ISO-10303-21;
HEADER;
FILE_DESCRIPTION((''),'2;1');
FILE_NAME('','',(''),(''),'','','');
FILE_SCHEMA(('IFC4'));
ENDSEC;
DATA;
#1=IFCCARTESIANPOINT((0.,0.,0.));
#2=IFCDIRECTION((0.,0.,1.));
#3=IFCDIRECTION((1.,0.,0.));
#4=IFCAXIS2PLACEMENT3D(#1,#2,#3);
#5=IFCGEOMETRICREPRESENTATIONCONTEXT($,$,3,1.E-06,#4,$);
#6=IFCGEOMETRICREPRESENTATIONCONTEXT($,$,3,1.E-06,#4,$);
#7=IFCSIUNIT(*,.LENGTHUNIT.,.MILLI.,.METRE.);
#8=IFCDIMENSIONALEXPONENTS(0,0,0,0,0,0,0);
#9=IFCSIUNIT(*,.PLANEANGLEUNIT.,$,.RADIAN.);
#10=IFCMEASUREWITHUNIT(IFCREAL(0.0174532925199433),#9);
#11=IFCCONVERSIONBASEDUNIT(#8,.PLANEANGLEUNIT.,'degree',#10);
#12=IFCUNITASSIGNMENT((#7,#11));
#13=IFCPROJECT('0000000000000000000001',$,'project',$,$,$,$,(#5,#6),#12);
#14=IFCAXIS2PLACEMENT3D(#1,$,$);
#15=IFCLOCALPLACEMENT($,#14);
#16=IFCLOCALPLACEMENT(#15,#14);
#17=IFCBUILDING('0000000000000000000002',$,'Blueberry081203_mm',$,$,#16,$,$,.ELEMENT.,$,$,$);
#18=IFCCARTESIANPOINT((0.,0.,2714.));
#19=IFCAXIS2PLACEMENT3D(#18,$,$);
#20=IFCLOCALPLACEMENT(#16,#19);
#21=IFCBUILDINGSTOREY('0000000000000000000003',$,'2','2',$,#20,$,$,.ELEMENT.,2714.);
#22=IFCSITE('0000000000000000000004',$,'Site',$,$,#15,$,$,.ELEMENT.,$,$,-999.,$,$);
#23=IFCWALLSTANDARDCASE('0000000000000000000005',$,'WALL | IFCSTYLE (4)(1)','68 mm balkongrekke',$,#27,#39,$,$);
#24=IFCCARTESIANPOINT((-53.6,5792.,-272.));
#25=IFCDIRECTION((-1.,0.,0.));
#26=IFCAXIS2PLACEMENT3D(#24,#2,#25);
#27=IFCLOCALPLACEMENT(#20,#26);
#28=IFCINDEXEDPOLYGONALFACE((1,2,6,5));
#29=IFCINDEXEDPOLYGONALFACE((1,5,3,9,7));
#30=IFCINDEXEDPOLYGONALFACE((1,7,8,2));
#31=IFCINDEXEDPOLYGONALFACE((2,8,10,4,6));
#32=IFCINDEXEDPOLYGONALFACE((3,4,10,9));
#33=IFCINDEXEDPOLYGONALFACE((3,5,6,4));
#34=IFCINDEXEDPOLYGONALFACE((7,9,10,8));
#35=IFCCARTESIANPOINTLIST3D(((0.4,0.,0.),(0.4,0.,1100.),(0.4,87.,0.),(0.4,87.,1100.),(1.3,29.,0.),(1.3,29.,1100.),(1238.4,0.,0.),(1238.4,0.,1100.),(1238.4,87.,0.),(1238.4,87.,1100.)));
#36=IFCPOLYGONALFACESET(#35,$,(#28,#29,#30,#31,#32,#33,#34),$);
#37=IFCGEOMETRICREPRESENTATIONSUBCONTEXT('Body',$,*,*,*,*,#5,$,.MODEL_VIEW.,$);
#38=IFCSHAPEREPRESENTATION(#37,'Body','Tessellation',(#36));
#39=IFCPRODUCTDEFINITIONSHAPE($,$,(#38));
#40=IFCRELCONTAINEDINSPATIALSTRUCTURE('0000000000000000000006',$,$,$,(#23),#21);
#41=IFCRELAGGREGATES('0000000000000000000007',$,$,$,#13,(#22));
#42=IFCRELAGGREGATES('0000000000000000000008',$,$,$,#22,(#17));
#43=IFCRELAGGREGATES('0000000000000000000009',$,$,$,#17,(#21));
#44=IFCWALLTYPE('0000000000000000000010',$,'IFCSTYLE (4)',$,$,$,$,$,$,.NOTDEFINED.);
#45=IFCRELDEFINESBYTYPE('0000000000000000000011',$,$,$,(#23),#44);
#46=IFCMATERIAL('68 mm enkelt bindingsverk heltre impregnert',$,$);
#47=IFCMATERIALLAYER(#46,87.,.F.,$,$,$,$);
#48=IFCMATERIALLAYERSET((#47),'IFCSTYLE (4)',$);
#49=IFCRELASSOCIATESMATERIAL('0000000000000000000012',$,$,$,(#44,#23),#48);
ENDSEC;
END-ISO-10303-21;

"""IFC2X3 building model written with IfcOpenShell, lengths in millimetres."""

from ifc_helpers import new_model, entity, si_unit, converted_unit, frame, origin, origin_with_axes, place, context, subcontext, project, spatial, polyline, segment, composite_curve, outline, extrude, material, layer, layer_set, layer_usage, type_object, element, save


model = new_model("IFC2X3")

# Units and contexts
context_of_model_1 = context(None, 3, precision=1e-06, world=origin_with_axes())
context_of_model_2 = context(None, 3, precision=1e-06, world=origin_with_axes())
body_context = subcontext(context_of_model_1, "Body", None, "MODEL_VIEW")
ifc_project = project(units=[si_unit("LENGTHUNIT", "METRE", prefix="MILLI"), converted_unit("PLANEANGLEUNIT", "degree", entity("IfcReal", 0.0174532925199433), si_unit("PLANEANGLEUNIT", "RADIAN"), dimensions=[0, 0, 0, 0, 0, 0, 0])], contexts=[context_of_model_1, context_of_model_2])

# Site, building, storey
site_placement = place(None, origin())
site = spatial("IfcSite", under=ifc_project, at=site_placement, Name="Site", CompositionType="ELEMENT", RefElevation=-999.0)
building_placement = place(site_placement, origin())
building = spatial("IfcBuilding", under=site, at=building_placement, Name="Blueberry081203_mm", CompositionType="ELEMENT")
storey_placement = place(building_placement, frame((0.0, 0.0, 2714.0)))
storey = spatial("IfcBuildingStorey", under=building, at=storey_placement, Name="2", Description="2", CompositionType="ELEMENT", Elevation=2714.0)

# Wall
ifc_material_1 = material(Name="68 mm enkelt bindingsverk heltre impregnert")
ifc_layer_1 = layer(ifc_material_1, 87.0, ventilated=False)
ifc_layer_set_1 = layer_set([ifc_layer_1], Name="IFCSTYLE (4)")
ifc_layer_usage_1 = layer_usage(ifc_layer_set_1, "AXIS2", "POSITIVE", 0.0)
wall_type = type_object("IfcWallType", Name="IFCSTYLE (4)", PredefinedType="NOTDEFINED", material=ifc_layer_set_1)
wall_1_placement = place(storey_placement, frame((-53.6, 5792.0, -272.0), z_axis=(0.0, 0.0, 1.0), x_axis=(-1.0, 0.0, 0.0)))
element("IfcWallStandardCase", 1, at=wall_1_placement, inside=storey, type_object=wall_type, material=ifc_layer_usage_1, Name="WALL | IFCSTYLE (4)(1)", Description="68 mm balkongrekke", context=body_context, shape_type="SweptSolid", held_by="IfcProductRepresentation", body=[
    extrude(outline(composite_curve([segment(polyline([(0.4, 87.0), (1.3, 29.0)]), True, "CONTINUOUS"), segment(polyline([(1.3, 29.0), (0.4, 0.0)]), True, "CONTINUOUS"), segment(polyline([(0.4, 0.0), (1238.4, 0.0)]), True, "CONTINUOUS"), segment(polyline([(1238.4, 0.0), (1238.4, 87.0)]), True, "CONTINUOUS"), segment(polyline([(1238.4, 87.0), (0.4, 87.0)]), True, "CONTINUOUS")], self_intersect=False)), origin(), (0.0, 0.0, 1.0), 1100.0),
])

save(model, "model.ifc")
